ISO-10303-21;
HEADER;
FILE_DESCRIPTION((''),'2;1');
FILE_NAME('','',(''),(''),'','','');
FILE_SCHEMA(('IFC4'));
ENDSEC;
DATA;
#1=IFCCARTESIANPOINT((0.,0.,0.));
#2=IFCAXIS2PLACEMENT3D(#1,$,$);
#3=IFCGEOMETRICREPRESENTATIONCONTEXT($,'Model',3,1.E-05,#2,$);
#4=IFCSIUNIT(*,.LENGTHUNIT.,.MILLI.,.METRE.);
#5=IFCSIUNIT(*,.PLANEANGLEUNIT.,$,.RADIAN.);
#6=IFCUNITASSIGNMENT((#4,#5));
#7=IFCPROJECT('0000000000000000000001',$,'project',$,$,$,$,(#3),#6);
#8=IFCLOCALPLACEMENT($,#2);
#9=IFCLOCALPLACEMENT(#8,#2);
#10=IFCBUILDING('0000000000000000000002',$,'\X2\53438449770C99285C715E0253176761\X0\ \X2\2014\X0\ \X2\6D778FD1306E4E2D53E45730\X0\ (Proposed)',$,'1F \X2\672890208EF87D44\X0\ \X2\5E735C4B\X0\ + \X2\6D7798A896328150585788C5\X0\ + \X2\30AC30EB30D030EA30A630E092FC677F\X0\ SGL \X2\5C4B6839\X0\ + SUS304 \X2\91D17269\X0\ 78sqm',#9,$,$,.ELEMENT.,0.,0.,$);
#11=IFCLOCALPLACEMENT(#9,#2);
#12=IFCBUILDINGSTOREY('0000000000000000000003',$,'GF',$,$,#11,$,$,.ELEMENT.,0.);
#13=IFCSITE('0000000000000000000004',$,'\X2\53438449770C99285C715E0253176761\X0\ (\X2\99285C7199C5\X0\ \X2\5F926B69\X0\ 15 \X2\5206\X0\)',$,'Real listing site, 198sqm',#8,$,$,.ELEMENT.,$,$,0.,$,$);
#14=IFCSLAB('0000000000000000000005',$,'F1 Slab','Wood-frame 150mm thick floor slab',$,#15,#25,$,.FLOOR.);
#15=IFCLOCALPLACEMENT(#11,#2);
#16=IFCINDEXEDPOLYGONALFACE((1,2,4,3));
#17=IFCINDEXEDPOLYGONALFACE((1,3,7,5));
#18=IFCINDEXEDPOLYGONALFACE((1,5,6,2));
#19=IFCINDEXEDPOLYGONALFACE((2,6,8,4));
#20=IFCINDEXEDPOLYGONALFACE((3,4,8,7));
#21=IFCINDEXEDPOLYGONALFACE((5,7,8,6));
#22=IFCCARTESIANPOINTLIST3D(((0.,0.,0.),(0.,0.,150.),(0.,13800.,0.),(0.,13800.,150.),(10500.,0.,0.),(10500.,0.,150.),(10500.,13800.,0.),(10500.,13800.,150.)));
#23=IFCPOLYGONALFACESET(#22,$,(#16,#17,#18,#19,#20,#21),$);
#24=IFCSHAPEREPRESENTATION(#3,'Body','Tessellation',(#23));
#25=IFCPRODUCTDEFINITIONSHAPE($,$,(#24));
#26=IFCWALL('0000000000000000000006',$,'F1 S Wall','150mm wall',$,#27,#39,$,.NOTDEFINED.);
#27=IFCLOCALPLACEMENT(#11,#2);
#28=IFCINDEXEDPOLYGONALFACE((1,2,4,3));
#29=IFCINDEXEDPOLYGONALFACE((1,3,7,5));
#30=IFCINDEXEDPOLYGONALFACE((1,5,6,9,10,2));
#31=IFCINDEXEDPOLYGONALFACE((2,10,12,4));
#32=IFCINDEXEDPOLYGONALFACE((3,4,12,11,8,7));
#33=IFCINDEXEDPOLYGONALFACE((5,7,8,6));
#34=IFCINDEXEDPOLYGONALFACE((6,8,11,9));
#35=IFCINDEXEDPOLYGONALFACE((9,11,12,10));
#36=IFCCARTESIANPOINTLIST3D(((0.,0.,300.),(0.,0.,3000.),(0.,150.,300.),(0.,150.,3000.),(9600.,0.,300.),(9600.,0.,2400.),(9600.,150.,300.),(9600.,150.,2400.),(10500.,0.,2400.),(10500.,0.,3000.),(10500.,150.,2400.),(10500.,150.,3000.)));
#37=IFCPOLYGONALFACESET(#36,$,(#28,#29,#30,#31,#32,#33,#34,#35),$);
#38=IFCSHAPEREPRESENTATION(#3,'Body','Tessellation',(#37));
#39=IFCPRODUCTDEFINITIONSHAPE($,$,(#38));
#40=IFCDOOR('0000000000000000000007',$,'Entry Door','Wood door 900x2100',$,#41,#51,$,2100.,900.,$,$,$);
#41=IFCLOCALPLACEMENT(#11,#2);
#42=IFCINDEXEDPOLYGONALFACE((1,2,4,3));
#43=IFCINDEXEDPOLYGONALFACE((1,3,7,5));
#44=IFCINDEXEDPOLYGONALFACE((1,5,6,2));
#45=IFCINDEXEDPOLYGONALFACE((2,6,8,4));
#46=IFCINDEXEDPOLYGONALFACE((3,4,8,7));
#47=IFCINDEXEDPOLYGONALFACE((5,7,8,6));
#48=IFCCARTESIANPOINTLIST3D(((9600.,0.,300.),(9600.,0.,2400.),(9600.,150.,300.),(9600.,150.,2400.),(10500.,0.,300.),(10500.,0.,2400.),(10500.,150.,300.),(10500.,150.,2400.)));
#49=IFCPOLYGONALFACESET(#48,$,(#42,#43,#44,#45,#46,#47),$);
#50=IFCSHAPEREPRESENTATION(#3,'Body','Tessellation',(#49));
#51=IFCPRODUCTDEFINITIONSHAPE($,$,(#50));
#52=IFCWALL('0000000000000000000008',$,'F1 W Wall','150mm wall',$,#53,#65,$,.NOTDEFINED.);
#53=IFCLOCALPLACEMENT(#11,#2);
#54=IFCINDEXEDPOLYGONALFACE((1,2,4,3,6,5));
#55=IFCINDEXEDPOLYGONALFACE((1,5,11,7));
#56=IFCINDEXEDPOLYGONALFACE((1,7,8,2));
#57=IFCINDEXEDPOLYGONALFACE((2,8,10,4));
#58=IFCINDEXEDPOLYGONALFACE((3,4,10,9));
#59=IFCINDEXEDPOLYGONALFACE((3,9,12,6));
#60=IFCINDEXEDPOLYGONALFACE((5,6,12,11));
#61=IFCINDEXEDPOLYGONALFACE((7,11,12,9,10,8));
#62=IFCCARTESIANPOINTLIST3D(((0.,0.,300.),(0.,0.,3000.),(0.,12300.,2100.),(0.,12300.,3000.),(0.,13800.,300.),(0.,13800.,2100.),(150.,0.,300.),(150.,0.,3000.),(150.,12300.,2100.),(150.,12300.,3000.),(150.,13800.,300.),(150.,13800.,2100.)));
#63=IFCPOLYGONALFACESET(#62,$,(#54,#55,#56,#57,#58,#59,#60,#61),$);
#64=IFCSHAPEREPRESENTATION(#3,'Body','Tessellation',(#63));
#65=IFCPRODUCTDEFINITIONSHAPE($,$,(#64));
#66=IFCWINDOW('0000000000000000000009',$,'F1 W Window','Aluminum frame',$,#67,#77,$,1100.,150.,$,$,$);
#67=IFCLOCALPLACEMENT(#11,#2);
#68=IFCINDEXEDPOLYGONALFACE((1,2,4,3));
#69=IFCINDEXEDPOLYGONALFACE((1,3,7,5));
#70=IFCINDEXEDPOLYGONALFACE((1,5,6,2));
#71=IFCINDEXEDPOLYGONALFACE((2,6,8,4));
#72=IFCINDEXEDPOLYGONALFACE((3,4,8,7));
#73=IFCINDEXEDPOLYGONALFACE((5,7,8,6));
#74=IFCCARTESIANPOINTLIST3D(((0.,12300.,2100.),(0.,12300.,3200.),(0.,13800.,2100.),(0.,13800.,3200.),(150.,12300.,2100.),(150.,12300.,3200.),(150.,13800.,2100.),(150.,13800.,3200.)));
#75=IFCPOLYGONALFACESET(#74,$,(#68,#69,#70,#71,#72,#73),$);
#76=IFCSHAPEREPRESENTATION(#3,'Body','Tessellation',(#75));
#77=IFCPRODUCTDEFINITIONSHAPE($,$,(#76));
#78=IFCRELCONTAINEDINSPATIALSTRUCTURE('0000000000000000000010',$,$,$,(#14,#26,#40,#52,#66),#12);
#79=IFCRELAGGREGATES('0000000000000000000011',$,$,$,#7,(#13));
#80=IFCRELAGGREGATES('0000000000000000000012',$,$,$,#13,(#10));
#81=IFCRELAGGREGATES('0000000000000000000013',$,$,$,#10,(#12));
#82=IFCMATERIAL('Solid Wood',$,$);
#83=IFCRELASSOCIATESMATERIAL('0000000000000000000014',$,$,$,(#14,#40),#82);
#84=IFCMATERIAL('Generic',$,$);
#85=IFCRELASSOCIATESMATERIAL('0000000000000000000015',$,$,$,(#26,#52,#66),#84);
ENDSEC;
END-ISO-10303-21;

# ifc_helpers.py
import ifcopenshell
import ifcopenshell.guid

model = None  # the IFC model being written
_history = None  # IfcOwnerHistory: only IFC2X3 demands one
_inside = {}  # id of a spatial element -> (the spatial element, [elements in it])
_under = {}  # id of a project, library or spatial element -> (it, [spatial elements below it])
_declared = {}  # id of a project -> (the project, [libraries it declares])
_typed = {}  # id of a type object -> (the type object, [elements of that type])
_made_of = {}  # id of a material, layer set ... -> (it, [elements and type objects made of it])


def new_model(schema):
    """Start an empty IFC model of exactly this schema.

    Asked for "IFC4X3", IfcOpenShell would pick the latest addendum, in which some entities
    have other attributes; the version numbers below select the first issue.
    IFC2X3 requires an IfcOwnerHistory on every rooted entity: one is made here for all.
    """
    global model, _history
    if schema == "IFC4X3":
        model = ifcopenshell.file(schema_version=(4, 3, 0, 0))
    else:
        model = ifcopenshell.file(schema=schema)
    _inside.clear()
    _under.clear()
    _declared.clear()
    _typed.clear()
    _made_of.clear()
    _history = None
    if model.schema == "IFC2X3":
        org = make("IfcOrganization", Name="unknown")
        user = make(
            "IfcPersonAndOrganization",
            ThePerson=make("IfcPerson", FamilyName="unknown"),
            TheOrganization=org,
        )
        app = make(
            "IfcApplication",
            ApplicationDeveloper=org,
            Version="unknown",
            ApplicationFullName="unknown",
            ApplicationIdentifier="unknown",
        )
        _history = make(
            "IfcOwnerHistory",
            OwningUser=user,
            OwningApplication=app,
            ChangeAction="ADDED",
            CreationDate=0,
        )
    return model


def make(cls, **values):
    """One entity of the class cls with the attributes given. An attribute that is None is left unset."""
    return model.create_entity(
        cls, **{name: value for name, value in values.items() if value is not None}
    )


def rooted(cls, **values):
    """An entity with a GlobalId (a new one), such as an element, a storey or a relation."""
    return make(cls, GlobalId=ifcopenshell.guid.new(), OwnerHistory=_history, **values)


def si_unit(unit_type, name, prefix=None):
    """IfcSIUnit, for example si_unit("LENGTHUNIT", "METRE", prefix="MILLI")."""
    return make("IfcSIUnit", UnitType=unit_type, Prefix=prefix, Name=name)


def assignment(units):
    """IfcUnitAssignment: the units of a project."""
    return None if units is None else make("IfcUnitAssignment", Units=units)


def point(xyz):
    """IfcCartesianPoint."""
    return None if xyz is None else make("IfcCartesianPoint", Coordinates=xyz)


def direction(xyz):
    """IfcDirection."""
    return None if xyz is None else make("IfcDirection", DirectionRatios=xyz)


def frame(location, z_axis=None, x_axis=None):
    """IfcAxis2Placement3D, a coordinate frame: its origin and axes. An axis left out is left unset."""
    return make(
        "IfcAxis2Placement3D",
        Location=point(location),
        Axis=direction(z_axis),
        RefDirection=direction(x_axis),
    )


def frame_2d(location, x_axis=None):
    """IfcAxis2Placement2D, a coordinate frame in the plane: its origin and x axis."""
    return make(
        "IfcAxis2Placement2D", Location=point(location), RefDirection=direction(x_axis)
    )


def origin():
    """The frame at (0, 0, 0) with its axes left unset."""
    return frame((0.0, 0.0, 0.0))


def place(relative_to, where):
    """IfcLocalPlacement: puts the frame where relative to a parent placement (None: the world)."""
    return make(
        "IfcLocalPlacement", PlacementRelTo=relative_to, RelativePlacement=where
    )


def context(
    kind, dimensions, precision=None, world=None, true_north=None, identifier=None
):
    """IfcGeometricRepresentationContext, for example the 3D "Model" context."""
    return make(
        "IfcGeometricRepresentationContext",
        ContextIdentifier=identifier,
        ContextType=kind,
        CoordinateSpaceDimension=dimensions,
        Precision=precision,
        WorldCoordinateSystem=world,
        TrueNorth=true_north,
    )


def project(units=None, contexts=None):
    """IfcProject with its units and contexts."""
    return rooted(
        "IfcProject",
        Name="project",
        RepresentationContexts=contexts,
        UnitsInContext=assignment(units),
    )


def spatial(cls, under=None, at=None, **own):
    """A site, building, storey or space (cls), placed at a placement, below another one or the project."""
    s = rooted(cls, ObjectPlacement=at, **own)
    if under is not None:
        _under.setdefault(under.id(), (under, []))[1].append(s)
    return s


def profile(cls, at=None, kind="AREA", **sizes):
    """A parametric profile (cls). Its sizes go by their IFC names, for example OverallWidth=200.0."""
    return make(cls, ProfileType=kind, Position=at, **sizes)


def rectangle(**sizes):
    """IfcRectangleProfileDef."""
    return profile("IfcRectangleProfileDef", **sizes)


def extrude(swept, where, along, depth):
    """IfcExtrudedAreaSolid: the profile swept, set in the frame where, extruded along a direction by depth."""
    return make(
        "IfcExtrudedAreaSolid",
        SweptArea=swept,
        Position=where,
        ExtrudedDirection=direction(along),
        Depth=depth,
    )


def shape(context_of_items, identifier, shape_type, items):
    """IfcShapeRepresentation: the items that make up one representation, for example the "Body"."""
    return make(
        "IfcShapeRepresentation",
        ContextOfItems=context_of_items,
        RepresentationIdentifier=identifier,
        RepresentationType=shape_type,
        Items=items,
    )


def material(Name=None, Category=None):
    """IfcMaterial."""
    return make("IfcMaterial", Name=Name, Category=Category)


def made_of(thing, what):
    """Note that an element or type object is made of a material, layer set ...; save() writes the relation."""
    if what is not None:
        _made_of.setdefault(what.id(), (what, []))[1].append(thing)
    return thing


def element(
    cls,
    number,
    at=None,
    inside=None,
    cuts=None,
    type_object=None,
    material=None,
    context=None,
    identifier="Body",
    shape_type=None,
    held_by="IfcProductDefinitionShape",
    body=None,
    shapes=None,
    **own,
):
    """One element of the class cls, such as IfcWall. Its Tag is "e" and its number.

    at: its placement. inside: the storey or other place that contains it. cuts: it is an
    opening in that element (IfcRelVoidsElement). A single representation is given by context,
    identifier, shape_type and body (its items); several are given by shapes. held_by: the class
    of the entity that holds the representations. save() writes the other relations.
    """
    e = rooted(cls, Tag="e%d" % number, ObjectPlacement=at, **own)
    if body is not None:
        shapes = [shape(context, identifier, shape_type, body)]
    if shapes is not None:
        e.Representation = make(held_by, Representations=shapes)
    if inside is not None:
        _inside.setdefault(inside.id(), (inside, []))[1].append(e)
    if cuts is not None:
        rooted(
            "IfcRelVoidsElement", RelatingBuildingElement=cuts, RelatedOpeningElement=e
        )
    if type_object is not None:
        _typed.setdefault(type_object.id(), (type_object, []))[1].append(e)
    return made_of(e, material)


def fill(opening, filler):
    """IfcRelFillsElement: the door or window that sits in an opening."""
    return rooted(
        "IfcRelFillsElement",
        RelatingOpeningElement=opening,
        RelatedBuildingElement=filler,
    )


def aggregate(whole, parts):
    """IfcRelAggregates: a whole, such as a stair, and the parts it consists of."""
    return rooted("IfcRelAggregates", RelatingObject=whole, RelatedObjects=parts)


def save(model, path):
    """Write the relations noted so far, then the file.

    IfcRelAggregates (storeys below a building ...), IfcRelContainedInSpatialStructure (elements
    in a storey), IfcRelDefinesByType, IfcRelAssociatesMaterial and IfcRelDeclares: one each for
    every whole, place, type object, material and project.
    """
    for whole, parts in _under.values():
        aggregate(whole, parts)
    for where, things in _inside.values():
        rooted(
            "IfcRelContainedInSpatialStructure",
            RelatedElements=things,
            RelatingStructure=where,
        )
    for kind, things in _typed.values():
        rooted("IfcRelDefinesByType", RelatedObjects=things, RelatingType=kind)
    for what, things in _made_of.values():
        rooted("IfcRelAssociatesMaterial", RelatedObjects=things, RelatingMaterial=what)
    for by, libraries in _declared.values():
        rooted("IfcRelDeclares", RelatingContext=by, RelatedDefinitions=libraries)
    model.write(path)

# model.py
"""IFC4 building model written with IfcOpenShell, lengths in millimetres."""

from ifc_helpers import new_model, si_unit, frame, frame_2d, origin, place, context, project, spatial, rectangle, extrude, material, element, fill, save


model = new_model("IFC4")

# Units and contexts
model_context = context("Model", 3, precision=1e-05, world=origin())
ifc_project = project(units=[si_unit("LENGTHUNIT", "METRE", prefix="MILLI"), si_unit("PLANEANGLEUNIT", "RADIAN")], contexts=[model_context])

# Site, building, storey
site_placement = place(None, origin())
site = spatial("IfcSite", under=ifc_project, at=site_placement, Name="千葉県館山市北条 (館山駅 徒歩 15 分)", ObjectType="Real listing site, 198sqm", CompositionType="ELEMENT", RefElevation=0.0)
building_placement = place(site_placement, origin())
building = spatial("IfcBuilding", under=site, at=building_placement, Name="千葉県館山市北条 — 海近の中古地 (Proposed)", ObjectType="1F 木造軸組 平屋 + 海風防腐塗装 + ガルバリウム鋼板 SGL 屋根 + SUS304 金物 78sqm", CompositionType="ELEMENT", ElevationOfRefHeight=0.0, ElevationOfTerrain=0.0)
storey_placement = place(building_placement, origin())
storey = spatial("IfcBuildingStorey", under=building, at=storey_placement, Name="GF", CompositionType="ELEMENT", Elevation=0.0)

# Slab
ifc_material_1 = material(Name="Solid Wood")
slab_placement = place(storey_placement, origin())
element("IfcSlab", 1, at=slab_placement, inside=storey, material=ifc_material_1, Name="F1 Slab", Description="Wood-frame 150mm thick floor slab", PredefinedType="FLOOR", context=model_context, shape_type="SweptSolid", body=[
    extrude(rectangle(XDim=10500.0, YDim=13800.0, at=frame_2d((5250.0, 6900.0))), origin(), (0.0, 0.0, 1.0), 150.0),
])

# Shared definitions
ifc_material_2 = material(Name="Generic")

# Wall, opening, door
wall_1_placement = place(storey_placement, frame((0.0, 0.0, 150.0)))
wall_1 = element("IfcWall", 2, at=wall_1_placement, inside=storey, material=ifc_material_2, Name="F1 S Wall", Description="150mm wall", PredefinedType="NOTDEFINED", context=model_context, shape_type="SweptSolid", body=[
    extrude(rectangle(XDim=10500.0, YDim=150.0, at=frame_2d((5250.0, 75.0))), frame((0.0, 0.0, 150.0)), (0.0, 0.0, 1.0), 2700.0),
])
opening_1_placement = place(storey_placement, frame((4800.0, 0.0, 150.0)))
opening_1 = element("IfcOpeningElement", 3, at=opening_1_placement, cuts=wall_1, PredefinedType="NOTDEFINED", context=model_context, shape_type="SweptSolid", body=[
    extrude(rectangle(XDim=900.0, YDim=150.0, at=frame_2d((450.0, 75.0))), frame((4800.0, 0.0, 150.0)), (0.0, 0.0, 1.0), 2100.0),
])
door_placement = place(storey_placement, frame((4800.0, 0.0, 150.0)))
door = element("IfcDoor", 4, at=door_placement, inside=storey, material=ifc_material_1, Name="Entry Door", Description="Wood door 900x2100", OverallHeight=2100.0, OverallWidth=900.0, context=model_context, shape_type="SweptSolid", body=[
    extrude(rectangle(XDim=900.0, YDim=150.0, at=frame_2d((450.0, 75.0))), frame((4800.0, 0.0, 150.0)), (0.0, 0.0, 1.0), 2100.0),
])
fill(opening_1, door)

# Wall, opening, window
wall_2_placement = place(storey_placement, frame((0.0, 0.0, 150.0)))
wall_2 = element("IfcWall", 5, at=wall_2_placement, inside=storey, material=ifc_material_2, Name="F1 W Wall", Description="150mm wall", PredefinedType="NOTDEFINED", context=model_context, shape_type="SweptSolid", body=[
    extrude(rectangle(XDim=150.0, YDim=13800.0, at=frame_2d((75.0, 6900.0))), frame((0.0, 0.0, 150.0)), (0.0, 0.0, 1.0), 2700.0),
])
opening_2_placement = place(storey_placement, frame((0.0, 6150.0, 1050.0)))
opening_2 = element("IfcOpeningElement", 6, at=opening_2_placement, cuts=wall_2, PredefinedType="NOTDEFINED", context=model_context, shape_type="SweptSolid", body=[
    extrude(rectangle(XDim=150.0, YDim=1500.0, at=frame_2d((75.0, 750.0))), frame((0.0, 6150.0, 1050.0)), (0.0, 0.0, 1.0), 1100.0),
])
window_1_placement = place(storey_placement, frame((0.0, 6150.0, 1050.0)))
window_1 = element("IfcWindow", 7, at=window_1_placement, inside=storey, material=ifc_material_2, Name="F1 W Window", Description="Aluminum frame", OverallHeight=1100.0, OverallWidth=150.0, context=model_context, shape_type="SweptSolid", body=[
    extrude(rectangle(XDim=150.0, YDim=1500.0, at=frame_2d((75.0, 750.0))), frame((0.0, 6150.0, 1050.0)), (0.0, 0.0, 1.0), 1100.0),
])
fill(opening_2, window_1)

save(model, "model.ifc")
